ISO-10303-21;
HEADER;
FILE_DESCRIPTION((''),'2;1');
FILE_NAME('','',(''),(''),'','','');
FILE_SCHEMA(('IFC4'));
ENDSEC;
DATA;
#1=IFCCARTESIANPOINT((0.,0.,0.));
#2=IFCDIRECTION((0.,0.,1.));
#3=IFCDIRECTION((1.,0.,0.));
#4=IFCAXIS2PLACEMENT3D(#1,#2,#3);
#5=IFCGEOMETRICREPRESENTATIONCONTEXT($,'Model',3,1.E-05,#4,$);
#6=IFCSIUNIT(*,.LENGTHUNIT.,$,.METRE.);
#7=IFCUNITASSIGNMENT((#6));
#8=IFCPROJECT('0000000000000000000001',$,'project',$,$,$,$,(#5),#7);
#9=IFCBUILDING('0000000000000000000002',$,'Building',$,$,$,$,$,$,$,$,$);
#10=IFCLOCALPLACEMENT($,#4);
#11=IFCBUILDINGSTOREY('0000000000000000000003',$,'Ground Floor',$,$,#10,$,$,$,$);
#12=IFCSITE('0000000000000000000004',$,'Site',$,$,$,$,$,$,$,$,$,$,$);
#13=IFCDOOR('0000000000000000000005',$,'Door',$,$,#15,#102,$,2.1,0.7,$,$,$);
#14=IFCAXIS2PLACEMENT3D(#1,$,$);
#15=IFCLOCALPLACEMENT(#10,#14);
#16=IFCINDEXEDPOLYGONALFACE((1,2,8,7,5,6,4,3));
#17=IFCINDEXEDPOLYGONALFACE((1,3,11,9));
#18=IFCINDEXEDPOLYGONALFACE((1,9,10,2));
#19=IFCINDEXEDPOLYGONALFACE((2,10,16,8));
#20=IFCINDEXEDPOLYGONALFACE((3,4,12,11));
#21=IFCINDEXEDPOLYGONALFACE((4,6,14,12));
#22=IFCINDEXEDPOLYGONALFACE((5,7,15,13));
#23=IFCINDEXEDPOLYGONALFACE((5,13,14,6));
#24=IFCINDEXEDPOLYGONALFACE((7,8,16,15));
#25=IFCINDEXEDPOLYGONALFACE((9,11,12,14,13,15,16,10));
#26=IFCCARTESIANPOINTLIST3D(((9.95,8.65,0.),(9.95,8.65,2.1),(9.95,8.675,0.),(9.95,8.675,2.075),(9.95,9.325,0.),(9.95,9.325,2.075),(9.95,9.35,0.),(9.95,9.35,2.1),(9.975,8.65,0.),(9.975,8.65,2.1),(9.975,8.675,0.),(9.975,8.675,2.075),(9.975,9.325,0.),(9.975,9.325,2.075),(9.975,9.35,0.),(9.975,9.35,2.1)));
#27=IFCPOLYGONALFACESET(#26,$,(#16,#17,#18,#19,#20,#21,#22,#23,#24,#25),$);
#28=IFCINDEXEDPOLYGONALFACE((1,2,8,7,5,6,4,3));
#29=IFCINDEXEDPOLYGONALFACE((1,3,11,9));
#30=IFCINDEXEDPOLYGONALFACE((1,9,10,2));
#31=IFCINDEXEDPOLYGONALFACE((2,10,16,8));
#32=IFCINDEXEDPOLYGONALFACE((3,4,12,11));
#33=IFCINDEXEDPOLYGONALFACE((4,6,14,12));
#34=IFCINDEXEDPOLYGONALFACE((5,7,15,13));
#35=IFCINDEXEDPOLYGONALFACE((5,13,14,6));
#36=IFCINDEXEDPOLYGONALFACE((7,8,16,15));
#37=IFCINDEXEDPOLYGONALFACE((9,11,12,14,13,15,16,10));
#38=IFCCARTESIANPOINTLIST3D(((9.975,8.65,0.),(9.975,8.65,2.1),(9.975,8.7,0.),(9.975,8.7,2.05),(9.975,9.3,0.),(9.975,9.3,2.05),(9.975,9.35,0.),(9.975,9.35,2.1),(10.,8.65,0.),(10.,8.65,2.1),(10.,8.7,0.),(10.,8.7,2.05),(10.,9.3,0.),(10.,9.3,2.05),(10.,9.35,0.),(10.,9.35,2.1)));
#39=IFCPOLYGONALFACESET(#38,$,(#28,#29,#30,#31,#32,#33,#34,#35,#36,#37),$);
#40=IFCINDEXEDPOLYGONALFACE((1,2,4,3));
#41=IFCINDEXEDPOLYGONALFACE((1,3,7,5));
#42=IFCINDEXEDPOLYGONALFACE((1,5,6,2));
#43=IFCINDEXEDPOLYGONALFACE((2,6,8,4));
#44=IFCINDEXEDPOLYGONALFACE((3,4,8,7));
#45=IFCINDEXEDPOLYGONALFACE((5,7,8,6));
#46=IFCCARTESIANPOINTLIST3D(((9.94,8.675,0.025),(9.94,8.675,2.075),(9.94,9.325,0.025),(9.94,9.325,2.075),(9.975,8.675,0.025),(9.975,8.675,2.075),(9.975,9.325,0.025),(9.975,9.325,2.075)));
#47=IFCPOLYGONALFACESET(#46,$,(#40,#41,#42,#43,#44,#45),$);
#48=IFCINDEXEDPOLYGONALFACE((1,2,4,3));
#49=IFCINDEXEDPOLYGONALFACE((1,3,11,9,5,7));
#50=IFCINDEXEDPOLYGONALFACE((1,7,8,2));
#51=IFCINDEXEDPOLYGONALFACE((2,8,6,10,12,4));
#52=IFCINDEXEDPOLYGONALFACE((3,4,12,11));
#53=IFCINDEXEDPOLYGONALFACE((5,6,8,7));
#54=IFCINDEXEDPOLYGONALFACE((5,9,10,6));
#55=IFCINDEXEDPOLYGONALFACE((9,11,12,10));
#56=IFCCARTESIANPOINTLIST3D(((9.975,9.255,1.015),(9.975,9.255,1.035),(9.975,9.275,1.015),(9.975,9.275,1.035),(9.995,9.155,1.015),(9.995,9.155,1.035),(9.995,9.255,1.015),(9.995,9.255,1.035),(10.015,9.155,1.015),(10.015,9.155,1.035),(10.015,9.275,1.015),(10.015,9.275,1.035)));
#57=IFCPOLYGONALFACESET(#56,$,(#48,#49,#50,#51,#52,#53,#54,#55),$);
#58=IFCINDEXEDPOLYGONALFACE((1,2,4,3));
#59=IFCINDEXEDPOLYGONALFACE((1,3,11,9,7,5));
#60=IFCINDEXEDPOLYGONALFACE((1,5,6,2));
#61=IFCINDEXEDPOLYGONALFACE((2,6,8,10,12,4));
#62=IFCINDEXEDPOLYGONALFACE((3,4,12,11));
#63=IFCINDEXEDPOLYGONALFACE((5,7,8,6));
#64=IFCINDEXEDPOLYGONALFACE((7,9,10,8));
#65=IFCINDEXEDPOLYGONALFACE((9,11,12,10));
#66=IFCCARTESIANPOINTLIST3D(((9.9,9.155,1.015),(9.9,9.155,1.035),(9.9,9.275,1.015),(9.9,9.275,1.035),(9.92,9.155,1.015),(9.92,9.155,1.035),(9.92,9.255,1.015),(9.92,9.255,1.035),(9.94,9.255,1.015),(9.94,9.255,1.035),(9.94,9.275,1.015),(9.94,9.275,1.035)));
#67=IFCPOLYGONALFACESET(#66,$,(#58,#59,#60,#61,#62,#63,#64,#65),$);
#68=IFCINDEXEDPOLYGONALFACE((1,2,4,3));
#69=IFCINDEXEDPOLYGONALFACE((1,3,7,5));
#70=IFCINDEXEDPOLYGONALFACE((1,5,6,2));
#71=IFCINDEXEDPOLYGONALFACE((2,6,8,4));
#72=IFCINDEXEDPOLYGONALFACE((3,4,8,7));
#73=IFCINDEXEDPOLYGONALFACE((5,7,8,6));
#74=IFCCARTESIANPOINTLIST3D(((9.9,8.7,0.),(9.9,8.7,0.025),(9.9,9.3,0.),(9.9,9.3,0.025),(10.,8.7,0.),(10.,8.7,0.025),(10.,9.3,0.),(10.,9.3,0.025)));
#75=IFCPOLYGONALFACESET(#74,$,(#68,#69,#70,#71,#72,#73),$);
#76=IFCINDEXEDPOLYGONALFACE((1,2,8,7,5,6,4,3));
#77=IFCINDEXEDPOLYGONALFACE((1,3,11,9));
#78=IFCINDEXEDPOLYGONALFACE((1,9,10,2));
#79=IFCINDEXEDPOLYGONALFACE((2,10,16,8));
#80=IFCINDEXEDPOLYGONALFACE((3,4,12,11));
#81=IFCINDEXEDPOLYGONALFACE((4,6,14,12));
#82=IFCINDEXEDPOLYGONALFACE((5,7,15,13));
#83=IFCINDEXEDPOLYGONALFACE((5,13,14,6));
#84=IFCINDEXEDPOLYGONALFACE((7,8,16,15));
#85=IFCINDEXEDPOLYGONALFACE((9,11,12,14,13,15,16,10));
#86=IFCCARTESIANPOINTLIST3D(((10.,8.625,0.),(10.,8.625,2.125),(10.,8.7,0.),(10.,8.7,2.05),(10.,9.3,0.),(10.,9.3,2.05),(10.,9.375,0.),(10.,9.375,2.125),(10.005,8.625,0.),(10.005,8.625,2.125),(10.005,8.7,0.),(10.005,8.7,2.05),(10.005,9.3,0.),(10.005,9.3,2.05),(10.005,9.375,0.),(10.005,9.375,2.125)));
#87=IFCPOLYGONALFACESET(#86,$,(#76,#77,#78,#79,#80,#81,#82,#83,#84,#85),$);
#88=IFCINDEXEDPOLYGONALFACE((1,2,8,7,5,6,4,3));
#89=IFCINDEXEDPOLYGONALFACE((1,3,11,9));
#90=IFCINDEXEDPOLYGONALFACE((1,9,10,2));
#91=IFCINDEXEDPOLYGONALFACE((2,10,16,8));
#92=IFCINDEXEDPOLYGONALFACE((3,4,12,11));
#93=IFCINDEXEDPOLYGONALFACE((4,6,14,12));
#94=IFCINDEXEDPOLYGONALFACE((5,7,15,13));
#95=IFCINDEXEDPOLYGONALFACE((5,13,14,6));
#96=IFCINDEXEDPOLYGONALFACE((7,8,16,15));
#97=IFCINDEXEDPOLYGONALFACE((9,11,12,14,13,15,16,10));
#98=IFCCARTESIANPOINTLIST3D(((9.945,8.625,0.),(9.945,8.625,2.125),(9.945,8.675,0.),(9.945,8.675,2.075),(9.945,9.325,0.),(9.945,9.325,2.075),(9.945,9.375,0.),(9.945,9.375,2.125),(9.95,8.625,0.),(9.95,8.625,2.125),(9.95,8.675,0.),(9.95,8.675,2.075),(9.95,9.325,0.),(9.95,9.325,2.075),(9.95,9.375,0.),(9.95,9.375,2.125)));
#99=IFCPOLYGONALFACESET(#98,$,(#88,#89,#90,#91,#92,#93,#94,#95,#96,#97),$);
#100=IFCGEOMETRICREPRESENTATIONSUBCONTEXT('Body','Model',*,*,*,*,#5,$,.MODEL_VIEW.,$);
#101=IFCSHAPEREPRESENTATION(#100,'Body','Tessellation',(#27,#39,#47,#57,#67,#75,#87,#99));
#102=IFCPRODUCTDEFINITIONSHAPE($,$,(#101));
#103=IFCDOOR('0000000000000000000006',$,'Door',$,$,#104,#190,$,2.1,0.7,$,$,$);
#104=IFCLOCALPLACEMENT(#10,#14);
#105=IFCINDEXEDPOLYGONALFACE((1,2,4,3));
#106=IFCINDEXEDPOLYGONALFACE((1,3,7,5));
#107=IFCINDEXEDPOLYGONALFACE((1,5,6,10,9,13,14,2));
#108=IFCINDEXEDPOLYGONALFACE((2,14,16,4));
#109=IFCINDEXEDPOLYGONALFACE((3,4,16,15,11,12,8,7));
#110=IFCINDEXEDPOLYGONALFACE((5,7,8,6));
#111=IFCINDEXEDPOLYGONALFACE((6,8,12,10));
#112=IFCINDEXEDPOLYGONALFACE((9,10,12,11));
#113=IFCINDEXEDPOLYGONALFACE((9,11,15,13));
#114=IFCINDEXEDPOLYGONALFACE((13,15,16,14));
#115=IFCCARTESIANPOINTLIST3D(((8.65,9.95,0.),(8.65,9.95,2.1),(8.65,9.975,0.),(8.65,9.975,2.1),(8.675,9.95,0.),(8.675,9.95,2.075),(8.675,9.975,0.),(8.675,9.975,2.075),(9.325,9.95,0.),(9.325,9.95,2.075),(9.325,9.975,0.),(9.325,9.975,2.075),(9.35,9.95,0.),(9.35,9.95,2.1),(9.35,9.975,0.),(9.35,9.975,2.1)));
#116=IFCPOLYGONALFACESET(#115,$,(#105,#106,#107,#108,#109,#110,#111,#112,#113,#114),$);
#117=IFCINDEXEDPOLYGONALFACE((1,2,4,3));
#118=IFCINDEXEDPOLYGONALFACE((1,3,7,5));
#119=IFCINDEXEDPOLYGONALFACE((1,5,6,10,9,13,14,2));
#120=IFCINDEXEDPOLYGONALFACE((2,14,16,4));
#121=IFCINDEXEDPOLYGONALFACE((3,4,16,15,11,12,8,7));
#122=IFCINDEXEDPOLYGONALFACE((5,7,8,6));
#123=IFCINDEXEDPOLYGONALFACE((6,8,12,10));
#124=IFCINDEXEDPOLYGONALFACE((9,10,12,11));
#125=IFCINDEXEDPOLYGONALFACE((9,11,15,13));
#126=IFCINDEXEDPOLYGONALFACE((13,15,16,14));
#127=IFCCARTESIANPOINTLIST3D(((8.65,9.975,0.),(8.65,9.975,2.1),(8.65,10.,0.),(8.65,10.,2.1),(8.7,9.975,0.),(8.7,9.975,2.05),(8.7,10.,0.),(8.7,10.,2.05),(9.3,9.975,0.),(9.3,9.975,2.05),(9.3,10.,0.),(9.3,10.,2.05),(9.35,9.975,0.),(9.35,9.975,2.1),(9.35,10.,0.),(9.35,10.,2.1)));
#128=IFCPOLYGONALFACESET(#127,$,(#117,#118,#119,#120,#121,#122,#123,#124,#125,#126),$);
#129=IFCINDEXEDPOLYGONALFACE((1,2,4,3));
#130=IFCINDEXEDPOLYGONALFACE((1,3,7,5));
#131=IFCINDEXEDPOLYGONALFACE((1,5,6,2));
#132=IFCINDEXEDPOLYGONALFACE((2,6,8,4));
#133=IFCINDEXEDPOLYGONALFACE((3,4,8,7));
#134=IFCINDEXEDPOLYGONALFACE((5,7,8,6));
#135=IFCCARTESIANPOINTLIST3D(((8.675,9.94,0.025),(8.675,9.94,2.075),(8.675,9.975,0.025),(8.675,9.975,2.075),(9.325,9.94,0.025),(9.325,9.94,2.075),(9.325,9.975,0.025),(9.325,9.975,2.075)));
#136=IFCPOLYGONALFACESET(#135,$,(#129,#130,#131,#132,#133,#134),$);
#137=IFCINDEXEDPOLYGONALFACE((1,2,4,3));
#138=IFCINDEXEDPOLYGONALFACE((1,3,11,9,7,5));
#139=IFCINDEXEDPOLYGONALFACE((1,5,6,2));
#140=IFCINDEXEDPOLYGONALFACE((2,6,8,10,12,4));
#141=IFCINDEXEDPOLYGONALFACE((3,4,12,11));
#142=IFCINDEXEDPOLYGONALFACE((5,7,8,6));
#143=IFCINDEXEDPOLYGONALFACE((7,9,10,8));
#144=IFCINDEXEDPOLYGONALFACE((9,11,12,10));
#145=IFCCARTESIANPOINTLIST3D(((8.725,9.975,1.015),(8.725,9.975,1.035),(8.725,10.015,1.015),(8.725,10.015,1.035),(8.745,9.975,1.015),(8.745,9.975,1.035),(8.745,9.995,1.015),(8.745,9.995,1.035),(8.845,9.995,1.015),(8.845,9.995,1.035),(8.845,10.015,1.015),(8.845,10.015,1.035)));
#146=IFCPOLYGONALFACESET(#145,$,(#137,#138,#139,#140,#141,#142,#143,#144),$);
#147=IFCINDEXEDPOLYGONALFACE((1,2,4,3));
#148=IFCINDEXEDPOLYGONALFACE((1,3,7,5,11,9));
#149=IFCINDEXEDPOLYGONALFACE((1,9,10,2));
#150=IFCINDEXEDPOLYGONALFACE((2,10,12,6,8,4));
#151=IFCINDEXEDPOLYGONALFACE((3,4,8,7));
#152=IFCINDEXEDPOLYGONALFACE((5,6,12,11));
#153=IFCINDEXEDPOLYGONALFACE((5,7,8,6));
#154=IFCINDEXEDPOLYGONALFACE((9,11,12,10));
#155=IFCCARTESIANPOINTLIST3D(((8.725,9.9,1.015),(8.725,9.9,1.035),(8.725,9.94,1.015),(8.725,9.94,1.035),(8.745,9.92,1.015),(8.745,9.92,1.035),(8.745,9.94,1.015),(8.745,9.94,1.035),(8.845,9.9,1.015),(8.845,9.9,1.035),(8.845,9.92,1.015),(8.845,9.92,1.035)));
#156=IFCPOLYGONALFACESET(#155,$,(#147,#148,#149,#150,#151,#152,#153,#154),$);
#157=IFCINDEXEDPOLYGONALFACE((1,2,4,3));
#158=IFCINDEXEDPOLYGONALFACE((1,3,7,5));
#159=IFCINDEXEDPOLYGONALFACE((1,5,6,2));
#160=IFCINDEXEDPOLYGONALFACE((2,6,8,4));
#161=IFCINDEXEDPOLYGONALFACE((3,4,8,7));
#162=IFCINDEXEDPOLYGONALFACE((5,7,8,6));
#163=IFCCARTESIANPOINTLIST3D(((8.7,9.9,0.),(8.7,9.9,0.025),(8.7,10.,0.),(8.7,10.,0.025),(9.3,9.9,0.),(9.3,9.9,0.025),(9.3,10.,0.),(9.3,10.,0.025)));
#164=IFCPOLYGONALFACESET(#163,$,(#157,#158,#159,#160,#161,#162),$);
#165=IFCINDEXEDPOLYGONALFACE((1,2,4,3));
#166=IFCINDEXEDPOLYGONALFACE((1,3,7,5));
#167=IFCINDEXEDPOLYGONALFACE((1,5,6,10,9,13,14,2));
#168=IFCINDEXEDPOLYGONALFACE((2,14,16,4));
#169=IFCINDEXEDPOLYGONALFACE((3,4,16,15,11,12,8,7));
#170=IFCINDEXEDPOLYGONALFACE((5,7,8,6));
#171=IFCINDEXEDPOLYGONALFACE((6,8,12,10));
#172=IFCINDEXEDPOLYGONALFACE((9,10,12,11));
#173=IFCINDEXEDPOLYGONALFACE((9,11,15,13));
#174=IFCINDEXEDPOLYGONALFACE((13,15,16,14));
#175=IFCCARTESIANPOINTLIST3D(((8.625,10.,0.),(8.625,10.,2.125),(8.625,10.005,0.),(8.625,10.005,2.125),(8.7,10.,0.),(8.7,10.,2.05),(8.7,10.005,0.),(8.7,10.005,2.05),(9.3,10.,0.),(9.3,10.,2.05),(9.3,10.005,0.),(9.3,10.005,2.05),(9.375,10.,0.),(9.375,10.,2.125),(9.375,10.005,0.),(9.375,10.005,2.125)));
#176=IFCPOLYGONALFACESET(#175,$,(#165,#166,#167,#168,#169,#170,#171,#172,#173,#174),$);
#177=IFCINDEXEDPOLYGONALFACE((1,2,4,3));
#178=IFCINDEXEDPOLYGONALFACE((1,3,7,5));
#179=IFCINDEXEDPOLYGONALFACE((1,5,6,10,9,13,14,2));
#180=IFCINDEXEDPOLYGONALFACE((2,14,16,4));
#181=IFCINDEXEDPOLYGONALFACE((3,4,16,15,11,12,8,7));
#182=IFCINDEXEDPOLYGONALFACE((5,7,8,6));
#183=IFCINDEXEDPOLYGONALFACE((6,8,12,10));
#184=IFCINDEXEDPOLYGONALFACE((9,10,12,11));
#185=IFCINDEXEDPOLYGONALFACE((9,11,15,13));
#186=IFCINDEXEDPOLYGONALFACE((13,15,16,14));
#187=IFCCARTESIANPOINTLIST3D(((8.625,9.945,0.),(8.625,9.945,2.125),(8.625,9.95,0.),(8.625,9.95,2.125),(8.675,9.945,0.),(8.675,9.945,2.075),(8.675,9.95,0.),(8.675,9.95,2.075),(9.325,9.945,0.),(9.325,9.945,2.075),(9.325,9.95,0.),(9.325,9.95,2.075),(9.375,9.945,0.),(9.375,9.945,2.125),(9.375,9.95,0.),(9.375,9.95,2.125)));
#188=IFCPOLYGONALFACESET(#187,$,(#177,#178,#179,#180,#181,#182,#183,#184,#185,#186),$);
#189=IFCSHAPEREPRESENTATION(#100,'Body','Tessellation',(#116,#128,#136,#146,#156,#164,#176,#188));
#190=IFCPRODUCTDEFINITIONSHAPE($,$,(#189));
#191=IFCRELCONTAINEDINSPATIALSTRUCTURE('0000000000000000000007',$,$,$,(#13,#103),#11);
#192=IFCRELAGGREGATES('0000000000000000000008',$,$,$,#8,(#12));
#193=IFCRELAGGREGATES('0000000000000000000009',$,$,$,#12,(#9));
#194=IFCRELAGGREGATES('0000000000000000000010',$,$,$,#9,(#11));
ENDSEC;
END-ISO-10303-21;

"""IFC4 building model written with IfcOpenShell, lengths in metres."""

from ifc_helpers import new_model, si_unit, frame, origin_with_axes, place, context, subcontext, project, spatial, line, indexed_curve, outline, extrude, element, save


model = new_model("IFC4")

# Units and contexts
model_context = context("Model", 3, precision=1e-05, world=origin_with_axes())
body_context = subcontext(model_context, "Body", "Model", "MODEL_VIEW")
ifc_project = project(units=[si_unit("LENGTHUNIT", "METRE")], contexts=[model_context])

# Site, building, storey
site = spatial("IfcSite", under=ifc_project, Name="Site")
building = spatial("IfcBuilding", under=site, Name="Building")
storey_placement = place(None, origin_with_axes())
storey = spatial("IfcBuildingStorey", under=building, at=storey_placement, Name="Ground Floor")

# Doors
door_1_placement = place(storey_placement, frame((10.0, 8.65, 0.0), z_axis=(0.0, 0.0, 1.0), x_axis=(0.0, 1.0, 0.0)))
element("IfcDoor", 1, at=door_1_placement, inside=storey, Name="Door", OverallHeight=2.1, OverallWidth=0.7, context=body_context, shape_type="SweptSolid", body=[
    extrude(outline(indexed_curve([(0.0, 0.0), (0.0, 2.1), (0.7, 2.1), (0.7, 0.0), (0.675, 0.0), (0.675, 2.075), (0.025, 2.075), (0.025, 0.0)], segments=[line(1, 2, 3, 4, 5, 6, 7, 8, 1)])), frame((0.0, 0.025, 0.0), z_axis=(0.0, -1.0, 0.0), x_axis=(1.0, 0.0, 0.0)), (0.0, 0.0, -1.0), 0.025),
    extrude(outline(indexed_curve([(0.0, 0.0), (0.0, 2.1), (0.7, 2.1), (0.7, 0.0), (0.65, 0.0), (0.65, 2.05), (0.05, 2.05), (0.05, 0.0)], segments=[line(1, 2, 3, 4, 5, 6, 7, 8, 1)])), frame((0.0, 0.0, 0.0), z_axis=(0.0, -1.0, 0.0), x_axis=(1.0, 0.0, 0.0)), (0.0, 0.0, -1.0), 0.025),
    extrude(outline(indexed_curve([(0.0, 0.0), (0.65, 0.0), (0.65, 0.035), (0.0, 0.035)], segments=[line(1, 2, 3, 4, 1)])), frame((0.025, 0.025, 0.025), z_axis=(0.0, 0.0, 1.0), x_axis=(1.0, 0.0, 0.0)), (0.0, 0.0, 1.0), 2.05),
    extrude(outline(indexed_curve([(0.0, 0.0), (0.0, -0.04), (-0.12, -0.04), (-0.12, -0.02), (-0.02, -0.02), (-0.02, 0.0)], segments=[line(1, 2, 3, 4, 5, 6, 1)])), frame((0.625, 0.025, 1.015), z_axis=(0.0, 0.0, 1.0), x_axis=(1.0, 0.0, 0.0)), (0.0, 0.0, 1.0), 0.02),
    extrude(outline(indexed_curve([(0.0, 0.0), (0.0, 0.04), (-0.12, 0.04), (-0.12, 0.02), (-0.02, 0.02), (-0.02, 0.0)], segments=[line(1, 2, 3, 4, 5, 6, 1)])), frame((0.625, 0.06, 1.015), z_axis=(0.0, 0.0, 1.0), x_axis=(1.0, 0.0, 0.0)), (0.0, 0.0, 1.0), 0.02),
    extrude(outline(indexed_curve([(0.0, 0.0), (0.6, 0.0), (0.6, 0.1), (0.0, 0.1)], segments=[line(1, 2, 3, 4, 1)])), frame((0.05, 0.0, 0.0), z_axis=(0.0, 0.0, 1.0), x_axis=(1.0, 0.0, 0.0)), (0.0, 0.0, 1.0), 0.025),
    extrude(outline(indexed_curve([(0.0, 0.0), (0.0, 2.125), (0.75, 2.125), (0.75, 0.0), (0.675, 0.0), (0.675, 2.05), (0.075, 2.05), (0.075, 0.0)], segments=[line(1, 2, 3, 4, 5, 6, 7, 8, 1)])), frame((-0.025, -0.005, 0.0), z_axis=(0.0, -1.0, 0.0), x_axis=(1.0, 0.0, 0.0)), (0.0, 0.0, -1.0), 0.005),
    extrude(outline(indexed_curve([(0.0, 0.0), (0.0, 2.125), (0.75, 2.125), (0.75, 0.0), (0.7, 0.0), (0.7, 2.075), (0.05, 2.075), (0.05, 0.0)], segments=[line(1, 2, 3, 4, 5, 6, 7, 8, 1)])), frame((-0.025, 0.05, 0.0), z_axis=(0.0, -1.0, 0.0), x_axis=(1.0, 0.0, 0.0)), (0.0, 0.0, -1.0), 0.005),
])
door_2_placement = place(storey_placement, frame((9.35, 10.0, 0.0), z_axis=(0.0, 0.0, 1.0), x_axis=(-1.0, 0.0, 0.0)))
element("IfcDoor", 2, at=door_2_placement, inside=storey, Name="Door", OverallHeight=2.1, OverallWidth=0.7, context=body_context, shape_type="SweptSolid", body=[
    extrude(outline(indexed_curve([(0.0, 0.0), (0.0, 2.1), (0.7, 2.1), (0.7, 0.0), (0.675, 0.0), (0.675, 2.075), (0.025, 2.075), (0.025, 0.0)], segments=[line(1, 2, 3, 4, 5, 6, 7, 8, 1)])), frame((0.0, 0.025, 0.0), z_axis=(0.0, -1.0, 0.0), x_axis=(1.0, 0.0, 0.0)), (0.0, 0.0, -1.0), 0.025),
    extrude(outline(indexed_curve([(0.0, 0.0), (0.0, 2.1), (0.7, 2.1), (0.7, 0.0), (0.65, 0.0), (0.65, 2.05), (0.05, 2.05), (0.05, 0.0)], segments=[line(1, 2, 3, 4, 5, 6, 7, 8, 1)])), frame((0.0, 0.0, 0.0), z_axis=(0.0, -1.0, 0.0), x_axis=(1.0, 0.0, 0.0)), (0.0, 0.0, -1.0), 0.025),
    extrude(outline(indexed_curve([(0.0, 0.0), (0.65, 0.0), (0.65, 0.035), (0.0, 0.035)], segments=[line(1, 2, 3, 4, 1)])), frame((0.025, 0.025, 0.025), z_axis=(0.0, 0.0, 1.0), x_axis=(1.0, 0.0, 0.0)), (0.0, 0.0, 1.0), 2.05),
    extrude(outline(indexed_curve([(0.0, 0.0), (0.0, -0.04), (-0.12, -0.04), (-0.12, -0.02), (-0.02, -0.02), (-0.02, 0.0)], segments=[line(1, 2, 3, 4, 5, 6, 1)])), frame((0.625, 0.025, 1.015), z_axis=(0.0, 0.0, 1.0), x_axis=(1.0, 0.0, 0.0)), (0.0, 0.0, 1.0), 0.02),
    extrude(outline(indexed_curve([(0.0, 0.0), (0.0, 0.04), (-0.12, 0.04), (-0.12, 0.02), (-0.02, 0.02), (-0.02, 0.0)], segments=[line(1, 2, 3, 4, 5, 6, 1)])), frame((0.625, 0.06, 1.015), z_axis=(0.0, 0.0, 1.0), x_axis=(1.0, 0.0, 0.0)), (0.0, 0.0, 1.0), 0.02),
    extrude(outline(indexed_curve([(0.0, 0.0), (0.6, 0.0), (0.6, 0.1), (0.0, 0.1)], segments=[line(1, 2, 3, 4, 1)])), frame((0.05, 0.0, 0.0), z_axis=(0.0, 0.0, 1.0), x_axis=(1.0, 0.0, 0.0)), (0.0, 0.0, 1.0), 0.025),
    extrude(outline(indexed_curve([(0.0, 0.0), (0.0, 2.125), (0.75, 2.125), (0.75, 0.0), (0.675, 0.0), (0.675, 2.05), (0.075, 2.05), (0.075, 0.0)], segments=[line(1, 2, 3, 4, 5, 6, 7, 8, 1)])), frame((-0.025, -0.005, 0.0), z_axis=(0.0, -1.0, 0.0), x_axis=(1.0, 0.0, 0.0)), (0.0, 0.0, -1.0), 0.005),
    extrude(outline(indexed_curve([(0.0, 0.0), (0.0, 2.125), (0.75, 2.125), (0.75, 0.0), (0.7, 0.0), (0.7, 2.075), (0.05, 2.075), (0.05, 0.0)], segments=[line(1, 2, 3, 4, 5, 6, 7, 8, 1)])), frame((-0.025, 0.05, 0.0), z_axis=(0.0, -1.0, 0.0), x_axis=(1.0, 0.0, 0.0)), (0.0, 0.0, -1.0), 0.005),
])

save(model, "model.ifc")
